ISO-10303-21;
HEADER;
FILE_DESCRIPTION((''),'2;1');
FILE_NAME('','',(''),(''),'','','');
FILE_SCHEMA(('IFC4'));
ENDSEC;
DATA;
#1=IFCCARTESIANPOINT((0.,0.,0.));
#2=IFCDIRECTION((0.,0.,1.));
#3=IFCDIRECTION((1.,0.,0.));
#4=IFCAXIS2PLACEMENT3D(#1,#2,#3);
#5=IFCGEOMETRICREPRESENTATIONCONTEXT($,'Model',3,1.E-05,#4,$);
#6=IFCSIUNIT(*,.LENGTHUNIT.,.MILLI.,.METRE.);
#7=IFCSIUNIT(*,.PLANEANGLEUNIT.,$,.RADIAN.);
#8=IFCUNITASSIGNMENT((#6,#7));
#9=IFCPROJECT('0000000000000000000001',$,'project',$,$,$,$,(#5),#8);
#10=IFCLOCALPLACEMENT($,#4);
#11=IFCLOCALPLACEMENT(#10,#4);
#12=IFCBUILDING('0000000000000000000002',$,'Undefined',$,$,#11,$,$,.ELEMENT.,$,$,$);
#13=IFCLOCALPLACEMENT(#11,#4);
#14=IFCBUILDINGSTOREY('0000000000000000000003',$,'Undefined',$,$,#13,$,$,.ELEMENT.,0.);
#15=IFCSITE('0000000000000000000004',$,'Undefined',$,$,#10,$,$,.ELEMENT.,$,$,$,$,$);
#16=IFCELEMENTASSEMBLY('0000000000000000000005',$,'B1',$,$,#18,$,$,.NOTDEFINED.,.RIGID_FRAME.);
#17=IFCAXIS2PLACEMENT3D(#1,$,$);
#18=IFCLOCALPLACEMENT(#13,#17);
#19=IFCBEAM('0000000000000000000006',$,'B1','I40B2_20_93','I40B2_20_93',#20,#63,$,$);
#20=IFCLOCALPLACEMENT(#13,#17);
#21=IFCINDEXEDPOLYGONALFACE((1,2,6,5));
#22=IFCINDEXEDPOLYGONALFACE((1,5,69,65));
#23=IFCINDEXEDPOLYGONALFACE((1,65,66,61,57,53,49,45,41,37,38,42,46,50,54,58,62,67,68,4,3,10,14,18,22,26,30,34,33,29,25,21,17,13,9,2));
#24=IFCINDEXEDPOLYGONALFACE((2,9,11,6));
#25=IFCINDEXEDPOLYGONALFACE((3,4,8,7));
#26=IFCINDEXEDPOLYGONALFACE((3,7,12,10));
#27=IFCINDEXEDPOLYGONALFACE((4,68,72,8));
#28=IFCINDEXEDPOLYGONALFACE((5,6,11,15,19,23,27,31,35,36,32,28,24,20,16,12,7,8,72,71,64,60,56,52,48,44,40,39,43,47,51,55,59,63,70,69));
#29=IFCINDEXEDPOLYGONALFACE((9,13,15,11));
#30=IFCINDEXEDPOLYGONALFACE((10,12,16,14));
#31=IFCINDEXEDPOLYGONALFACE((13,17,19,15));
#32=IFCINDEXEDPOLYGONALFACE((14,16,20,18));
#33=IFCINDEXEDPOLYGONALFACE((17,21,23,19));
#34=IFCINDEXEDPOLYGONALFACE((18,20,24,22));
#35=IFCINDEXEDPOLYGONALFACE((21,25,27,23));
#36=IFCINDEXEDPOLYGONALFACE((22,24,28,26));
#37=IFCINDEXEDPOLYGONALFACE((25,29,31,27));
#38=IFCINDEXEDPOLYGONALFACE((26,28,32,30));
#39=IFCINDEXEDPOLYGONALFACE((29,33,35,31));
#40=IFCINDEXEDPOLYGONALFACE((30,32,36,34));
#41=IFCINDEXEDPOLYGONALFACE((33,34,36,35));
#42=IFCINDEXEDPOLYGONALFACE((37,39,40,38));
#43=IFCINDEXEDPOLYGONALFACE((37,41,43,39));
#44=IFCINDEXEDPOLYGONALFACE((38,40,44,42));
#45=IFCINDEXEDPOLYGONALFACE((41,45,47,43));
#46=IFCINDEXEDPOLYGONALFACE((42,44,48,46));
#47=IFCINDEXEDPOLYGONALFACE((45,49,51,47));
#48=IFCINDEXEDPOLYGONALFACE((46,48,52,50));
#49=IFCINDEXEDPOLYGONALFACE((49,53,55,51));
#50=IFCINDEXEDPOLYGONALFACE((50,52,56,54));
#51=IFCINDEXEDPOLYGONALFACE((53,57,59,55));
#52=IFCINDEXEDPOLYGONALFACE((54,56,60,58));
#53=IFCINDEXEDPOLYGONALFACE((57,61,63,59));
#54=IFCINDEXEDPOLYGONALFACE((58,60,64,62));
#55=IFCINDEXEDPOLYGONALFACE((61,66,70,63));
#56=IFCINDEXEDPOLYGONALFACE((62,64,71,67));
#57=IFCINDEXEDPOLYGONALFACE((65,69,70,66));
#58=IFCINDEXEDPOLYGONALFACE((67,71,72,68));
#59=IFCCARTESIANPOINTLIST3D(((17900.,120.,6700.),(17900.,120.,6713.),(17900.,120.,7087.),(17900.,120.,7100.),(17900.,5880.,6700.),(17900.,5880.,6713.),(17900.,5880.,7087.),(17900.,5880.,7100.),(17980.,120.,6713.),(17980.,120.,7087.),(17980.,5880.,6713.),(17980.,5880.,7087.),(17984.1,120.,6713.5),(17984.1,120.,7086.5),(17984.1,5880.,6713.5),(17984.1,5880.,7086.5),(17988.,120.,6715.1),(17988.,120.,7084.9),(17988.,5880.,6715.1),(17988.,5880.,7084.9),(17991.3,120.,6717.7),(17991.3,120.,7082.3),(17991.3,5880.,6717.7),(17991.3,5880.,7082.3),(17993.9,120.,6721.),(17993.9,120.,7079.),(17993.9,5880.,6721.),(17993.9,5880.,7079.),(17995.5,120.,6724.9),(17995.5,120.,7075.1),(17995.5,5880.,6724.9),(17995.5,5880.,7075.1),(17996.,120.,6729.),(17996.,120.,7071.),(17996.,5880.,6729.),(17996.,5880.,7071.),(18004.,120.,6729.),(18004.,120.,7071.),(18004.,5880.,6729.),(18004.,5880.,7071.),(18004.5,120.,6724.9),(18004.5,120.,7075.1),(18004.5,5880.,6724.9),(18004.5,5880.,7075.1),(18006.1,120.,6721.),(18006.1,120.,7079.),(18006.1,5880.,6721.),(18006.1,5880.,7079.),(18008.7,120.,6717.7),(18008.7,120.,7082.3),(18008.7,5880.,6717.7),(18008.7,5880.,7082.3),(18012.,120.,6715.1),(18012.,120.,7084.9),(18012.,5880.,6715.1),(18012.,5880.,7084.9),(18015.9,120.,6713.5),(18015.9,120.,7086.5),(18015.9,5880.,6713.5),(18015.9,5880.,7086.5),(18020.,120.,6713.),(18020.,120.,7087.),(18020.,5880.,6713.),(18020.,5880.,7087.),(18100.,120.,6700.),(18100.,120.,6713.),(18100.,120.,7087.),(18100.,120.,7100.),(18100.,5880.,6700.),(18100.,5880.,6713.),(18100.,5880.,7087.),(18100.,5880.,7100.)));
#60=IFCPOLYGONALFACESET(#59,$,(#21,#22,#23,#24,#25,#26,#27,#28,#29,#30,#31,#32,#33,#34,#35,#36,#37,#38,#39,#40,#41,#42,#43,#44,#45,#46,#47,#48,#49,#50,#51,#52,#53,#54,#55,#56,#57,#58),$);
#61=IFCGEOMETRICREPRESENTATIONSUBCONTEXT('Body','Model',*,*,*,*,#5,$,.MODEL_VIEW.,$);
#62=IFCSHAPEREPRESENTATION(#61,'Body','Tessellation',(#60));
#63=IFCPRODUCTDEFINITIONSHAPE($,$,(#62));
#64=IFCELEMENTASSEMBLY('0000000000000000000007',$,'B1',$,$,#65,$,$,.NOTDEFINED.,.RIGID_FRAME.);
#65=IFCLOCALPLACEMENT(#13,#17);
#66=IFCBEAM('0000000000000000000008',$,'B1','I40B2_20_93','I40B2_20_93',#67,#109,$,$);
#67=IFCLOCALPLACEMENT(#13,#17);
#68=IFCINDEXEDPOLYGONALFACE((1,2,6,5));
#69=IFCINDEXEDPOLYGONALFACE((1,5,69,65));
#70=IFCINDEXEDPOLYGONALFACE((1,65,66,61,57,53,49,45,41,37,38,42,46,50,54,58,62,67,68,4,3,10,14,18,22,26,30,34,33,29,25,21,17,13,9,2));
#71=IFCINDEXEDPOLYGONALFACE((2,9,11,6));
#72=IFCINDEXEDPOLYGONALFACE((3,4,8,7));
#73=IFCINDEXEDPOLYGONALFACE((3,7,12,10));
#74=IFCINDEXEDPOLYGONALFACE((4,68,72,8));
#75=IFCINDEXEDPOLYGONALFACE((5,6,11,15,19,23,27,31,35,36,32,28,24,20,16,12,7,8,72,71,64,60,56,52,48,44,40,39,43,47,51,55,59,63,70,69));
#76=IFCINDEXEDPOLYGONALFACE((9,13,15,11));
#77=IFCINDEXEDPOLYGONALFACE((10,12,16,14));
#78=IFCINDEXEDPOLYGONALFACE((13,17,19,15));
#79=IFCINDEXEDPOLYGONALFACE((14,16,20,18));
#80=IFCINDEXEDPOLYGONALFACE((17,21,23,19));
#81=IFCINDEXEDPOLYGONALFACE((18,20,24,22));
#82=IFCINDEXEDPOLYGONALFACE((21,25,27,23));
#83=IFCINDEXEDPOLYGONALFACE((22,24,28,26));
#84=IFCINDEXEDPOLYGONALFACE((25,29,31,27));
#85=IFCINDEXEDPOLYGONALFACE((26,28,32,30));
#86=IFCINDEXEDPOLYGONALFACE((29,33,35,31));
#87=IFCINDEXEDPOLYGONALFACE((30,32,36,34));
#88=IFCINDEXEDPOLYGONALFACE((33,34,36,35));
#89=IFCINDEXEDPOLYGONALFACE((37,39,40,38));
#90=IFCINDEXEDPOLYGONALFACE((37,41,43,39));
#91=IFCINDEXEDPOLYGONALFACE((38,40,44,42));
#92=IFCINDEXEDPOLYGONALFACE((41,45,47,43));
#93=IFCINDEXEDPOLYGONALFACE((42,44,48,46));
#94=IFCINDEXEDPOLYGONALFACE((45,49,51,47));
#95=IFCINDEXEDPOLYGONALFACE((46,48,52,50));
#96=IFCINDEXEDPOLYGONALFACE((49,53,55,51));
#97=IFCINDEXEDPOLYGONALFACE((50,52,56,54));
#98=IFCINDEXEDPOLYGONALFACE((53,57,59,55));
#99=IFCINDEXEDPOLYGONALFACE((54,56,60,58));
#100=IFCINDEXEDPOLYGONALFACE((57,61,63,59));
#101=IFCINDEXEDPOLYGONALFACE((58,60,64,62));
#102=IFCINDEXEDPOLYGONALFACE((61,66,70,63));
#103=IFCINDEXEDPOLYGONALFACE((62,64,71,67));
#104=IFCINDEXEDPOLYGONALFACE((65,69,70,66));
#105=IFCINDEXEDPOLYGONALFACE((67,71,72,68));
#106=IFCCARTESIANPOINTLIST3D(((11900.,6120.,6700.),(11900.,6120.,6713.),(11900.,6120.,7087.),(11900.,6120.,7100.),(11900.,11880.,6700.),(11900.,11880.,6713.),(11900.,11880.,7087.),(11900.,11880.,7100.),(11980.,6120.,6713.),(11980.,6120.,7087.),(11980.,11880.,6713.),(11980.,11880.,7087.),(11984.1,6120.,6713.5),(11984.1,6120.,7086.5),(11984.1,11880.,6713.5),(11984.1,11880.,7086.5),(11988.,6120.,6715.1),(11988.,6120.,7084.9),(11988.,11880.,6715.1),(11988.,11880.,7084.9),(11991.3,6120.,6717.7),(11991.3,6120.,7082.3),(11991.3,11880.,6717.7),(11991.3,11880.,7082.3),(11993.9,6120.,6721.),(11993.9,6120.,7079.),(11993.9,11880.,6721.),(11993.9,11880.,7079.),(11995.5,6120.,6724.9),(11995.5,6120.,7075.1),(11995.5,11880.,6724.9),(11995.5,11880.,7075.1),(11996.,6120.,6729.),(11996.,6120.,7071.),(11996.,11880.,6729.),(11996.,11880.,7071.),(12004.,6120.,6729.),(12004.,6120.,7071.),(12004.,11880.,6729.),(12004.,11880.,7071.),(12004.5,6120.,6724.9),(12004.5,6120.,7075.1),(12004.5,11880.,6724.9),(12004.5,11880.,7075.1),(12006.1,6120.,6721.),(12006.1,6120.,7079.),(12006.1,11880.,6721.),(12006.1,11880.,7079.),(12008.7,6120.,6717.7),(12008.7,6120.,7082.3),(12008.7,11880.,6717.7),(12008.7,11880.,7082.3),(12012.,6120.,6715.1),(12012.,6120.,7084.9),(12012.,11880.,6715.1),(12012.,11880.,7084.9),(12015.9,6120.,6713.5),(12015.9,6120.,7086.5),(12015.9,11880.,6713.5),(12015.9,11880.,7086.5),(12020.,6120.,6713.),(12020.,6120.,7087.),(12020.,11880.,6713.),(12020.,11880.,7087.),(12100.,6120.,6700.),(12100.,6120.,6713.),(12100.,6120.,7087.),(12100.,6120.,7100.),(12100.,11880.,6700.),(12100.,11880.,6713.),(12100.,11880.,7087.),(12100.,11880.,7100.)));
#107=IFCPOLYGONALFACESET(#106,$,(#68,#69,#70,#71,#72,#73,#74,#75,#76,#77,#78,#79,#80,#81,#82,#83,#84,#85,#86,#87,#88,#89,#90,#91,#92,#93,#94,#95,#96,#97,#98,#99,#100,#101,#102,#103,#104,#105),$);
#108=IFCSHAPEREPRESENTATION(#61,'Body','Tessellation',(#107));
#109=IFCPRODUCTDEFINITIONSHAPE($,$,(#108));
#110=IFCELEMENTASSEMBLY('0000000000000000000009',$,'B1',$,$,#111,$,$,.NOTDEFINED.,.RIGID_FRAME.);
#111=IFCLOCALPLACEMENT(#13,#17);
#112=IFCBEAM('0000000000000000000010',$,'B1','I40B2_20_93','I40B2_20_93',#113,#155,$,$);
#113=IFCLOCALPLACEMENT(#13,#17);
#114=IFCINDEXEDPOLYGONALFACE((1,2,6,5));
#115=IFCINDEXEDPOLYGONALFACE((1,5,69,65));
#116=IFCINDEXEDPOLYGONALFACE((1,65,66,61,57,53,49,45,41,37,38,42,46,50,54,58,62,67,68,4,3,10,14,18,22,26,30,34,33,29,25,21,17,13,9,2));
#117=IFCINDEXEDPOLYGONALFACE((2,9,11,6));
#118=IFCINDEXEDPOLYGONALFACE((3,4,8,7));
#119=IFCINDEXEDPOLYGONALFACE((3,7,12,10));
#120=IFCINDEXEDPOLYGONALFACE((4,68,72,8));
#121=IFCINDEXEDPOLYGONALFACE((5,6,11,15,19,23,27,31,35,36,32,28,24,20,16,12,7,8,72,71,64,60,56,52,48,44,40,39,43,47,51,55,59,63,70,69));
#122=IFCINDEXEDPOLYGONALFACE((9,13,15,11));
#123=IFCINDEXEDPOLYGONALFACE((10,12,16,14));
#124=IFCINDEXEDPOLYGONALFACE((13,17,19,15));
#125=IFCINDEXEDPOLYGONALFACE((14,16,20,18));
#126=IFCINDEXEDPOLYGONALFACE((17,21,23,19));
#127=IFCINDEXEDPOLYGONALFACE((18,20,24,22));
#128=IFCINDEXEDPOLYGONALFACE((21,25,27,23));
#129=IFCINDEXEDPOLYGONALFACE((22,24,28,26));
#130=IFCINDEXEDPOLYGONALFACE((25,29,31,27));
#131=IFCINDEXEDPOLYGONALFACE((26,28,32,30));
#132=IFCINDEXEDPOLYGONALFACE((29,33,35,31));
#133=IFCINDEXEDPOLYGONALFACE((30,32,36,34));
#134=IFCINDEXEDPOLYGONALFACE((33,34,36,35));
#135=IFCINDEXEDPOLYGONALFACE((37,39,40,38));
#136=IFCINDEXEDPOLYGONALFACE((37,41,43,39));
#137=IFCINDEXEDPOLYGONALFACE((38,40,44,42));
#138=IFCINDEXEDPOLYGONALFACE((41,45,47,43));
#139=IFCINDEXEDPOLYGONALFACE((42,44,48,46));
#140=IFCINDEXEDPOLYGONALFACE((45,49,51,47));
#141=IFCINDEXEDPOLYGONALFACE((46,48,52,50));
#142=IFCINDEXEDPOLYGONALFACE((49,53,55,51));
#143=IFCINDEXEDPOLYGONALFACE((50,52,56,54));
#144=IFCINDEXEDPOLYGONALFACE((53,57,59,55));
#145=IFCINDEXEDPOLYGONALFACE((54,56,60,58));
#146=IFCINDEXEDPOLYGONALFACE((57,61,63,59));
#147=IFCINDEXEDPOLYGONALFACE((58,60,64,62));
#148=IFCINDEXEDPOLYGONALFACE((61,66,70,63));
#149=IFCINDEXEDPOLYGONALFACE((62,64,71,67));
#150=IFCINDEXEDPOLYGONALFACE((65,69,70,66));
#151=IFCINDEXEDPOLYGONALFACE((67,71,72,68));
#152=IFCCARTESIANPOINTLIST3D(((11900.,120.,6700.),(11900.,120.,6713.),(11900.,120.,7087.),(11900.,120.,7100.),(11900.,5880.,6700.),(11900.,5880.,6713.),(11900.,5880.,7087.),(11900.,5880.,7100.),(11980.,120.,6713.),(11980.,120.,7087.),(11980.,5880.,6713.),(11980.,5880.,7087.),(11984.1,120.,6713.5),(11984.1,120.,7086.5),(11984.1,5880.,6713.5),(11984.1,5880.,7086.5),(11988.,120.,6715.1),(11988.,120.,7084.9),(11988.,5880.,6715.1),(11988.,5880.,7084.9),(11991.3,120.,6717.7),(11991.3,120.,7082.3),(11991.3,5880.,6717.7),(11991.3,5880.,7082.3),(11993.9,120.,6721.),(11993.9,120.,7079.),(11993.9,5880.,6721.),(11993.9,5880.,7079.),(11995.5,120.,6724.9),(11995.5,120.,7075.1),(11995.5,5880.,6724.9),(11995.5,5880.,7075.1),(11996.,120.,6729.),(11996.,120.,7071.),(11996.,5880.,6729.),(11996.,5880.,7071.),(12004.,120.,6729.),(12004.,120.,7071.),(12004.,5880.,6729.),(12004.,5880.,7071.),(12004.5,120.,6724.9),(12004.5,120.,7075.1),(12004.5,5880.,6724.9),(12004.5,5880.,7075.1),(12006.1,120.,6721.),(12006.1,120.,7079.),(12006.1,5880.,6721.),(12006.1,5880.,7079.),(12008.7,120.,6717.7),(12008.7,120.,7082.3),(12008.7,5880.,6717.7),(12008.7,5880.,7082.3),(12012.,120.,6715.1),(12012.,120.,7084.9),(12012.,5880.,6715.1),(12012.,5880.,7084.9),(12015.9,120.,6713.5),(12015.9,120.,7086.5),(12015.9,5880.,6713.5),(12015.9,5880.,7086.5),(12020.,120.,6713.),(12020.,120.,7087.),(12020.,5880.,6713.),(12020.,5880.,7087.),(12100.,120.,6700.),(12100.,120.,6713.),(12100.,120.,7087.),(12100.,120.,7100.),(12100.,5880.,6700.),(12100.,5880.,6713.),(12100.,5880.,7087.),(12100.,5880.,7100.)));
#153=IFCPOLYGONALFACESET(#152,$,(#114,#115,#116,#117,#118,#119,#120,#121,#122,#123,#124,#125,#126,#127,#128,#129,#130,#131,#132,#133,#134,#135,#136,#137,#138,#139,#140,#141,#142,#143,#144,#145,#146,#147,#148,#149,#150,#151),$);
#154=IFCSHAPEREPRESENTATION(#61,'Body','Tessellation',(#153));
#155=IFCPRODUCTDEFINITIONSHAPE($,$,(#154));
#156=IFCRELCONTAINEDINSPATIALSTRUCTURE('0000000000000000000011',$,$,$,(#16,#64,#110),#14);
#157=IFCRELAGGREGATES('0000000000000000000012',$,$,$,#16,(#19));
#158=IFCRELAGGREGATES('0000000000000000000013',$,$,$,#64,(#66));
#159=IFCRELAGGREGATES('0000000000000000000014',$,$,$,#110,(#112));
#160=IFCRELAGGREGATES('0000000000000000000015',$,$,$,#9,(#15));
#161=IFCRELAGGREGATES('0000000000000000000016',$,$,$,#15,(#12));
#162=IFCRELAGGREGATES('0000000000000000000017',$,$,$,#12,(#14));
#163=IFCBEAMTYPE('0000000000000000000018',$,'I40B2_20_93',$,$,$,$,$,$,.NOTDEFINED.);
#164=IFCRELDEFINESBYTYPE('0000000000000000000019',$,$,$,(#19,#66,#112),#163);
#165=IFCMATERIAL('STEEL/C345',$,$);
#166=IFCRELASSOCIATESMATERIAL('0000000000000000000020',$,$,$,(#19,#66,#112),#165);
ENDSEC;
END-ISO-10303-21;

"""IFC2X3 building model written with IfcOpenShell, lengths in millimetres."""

from ifc_helpers import new_model, si_unit, frame, origin_with_axes, origin_2d_with_axis, place, context, subcontext, project, spatial, i_section, extrude, material, type_object, element, aggregate, save


model = new_model("IFC2X3")

# Units and contexts
model_context = context("Model", 3, precision=1e-05, world=origin_with_axes())
body_context = subcontext(model_context, "Body", "Model", "MODEL_VIEW")
ifc_project = project(units=[si_unit("LENGTHUNIT", "METRE", prefix="MILLI"), si_unit("PLANEANGLEUNIT", "RADIAN")], contexts=[model_context])

# Site, building, storey
site_placement = place(None, origin_with_axes())
site = spatial("IfcSite", under=ifc_project, at=site_placement, Name="Undefined", CompositionType="ELEMENT")
building_placement = place(site_placement, origin_with_axes())
building = spatial("IfcBuilding", under=site, at=building_placement, Name="Undefined", CompositionType="ELEMENT")
storey_placement = place(building_placement, origin_with_axes())
storey = spatial("IfcBuildingStorey", under=building, at=storey_placement, Name="Undefined", CompositionType="ELEMENT", Elevation=0.0)

# Element assemblies, beams
ifc_material_1 = material(Name="STEEL/C345")
beam_type_1 = type_object("IfcBeamType", Name="I40B2_20_93", PredefinedType="NOTDEFINED")
assembly_1_placement = place(storey_placement, origin_with_axes())
assembly_1 = element("IfcElementAssembly", 1, at=assembly_1_placement, inside=storey, Name="B1", AssemblyPlace="NOTDEFINED", PredefinedType="RIGID_FRAME")
beam_1_placement = place(assembly_1_placement, frame((18000.0, 120.0, 6900.0), z_axis=(0.0, 0.0, 1.0), x_axis=(0.0, 1.0, 0.0)))
beam_1 = element("IfcBeam", 2, at=beam_1_placement, type_object=beam_type_1, material=ifc_material_1, Name="B1", Description="I40B2_20_93", ObjectType="I40B2_20_93", context=body_context, shape_type="SweptSolid", body=[
    extrude(i_section(OverallWidth=200.0, OverallDepth=400.0, WebThickness=8.0, FlangeThickness=13.0, FilletRadius=16.0, at=origin_2d_with_axis()), frame((5760.0, 0.0, 0.0), z_axis=(-1.0, 0.0, 0.0), x_axis=(0.0, -1.0, 0.0)), (0.0, 0.0, 1.0), 5760.0),
])
aggregate(assembly_1, [beam_1])
assembly_2_placement = place(storey_placement, origin_with_axes())
assembly_2 = element("IfcElementAssembly", 3, at=assembly_2_placement, inside=storey, Name="B1", AssemblyPlace="NOTDEFINED", PredefinedType="RIGID_FRAME")
beam_2_placement = place(assembly_2_placement, frame((12000.0, 6120.0, 6900.0), z_axis=(0.0, 0.0, 1.0), x_axis=(0.0, 1.0, 0.0)))
beam_2 = element("IfcBeam", 4, at=beam_2_placement, type_object=beam_type_1, material=ifc_material_1, Name="B1", Description="I40B2_20_93", ObjectType="I40B2_20_93", context=body_context, shape_type="SweptSolid", body=[
    extrude(i_section(OverallWidth=200.0, OverallDepth=400.0, WebThickness=8.0, FlangeThickness=13.0, FilletRadius=16.0, at=origin_2d_with_axis()), frame((5760.0, 0.0, 0.0), z_axis=(-1.0, 0.0, 0.0), x_axis=(0.0, -1.0, 0.0)), (0.0, 0.0, 1.0), 5760.0),
])
aggregate(assembly_2, [beam_2])
assembly_3_placement = place(storey_placement, origin_with_axes())
assembly_3 = element("IfcElementAssembly", 5, at=assembly_3_placement, inside=storey, Name="B1", AssemblyPlace="NOTDEFINED", PredefinedType="RIGID_FRAME")
beam_3_placement = place(assembly_3_placement, frame((12000.0, 120.0, 6900.0), z_axis=(0.0, 0.0, 1.0), x_axis=(0.0, 1.0, 0.0)))
beam_3 = element("IfcBeam", 6, at=beam_3_placement, type_object=beam_type_1, material=ifc_material_1, Name="B1", Description="I40B2_20_93", ObjectType="I40B2_20_93", context=body_context, shape_type="SweptSolid", body=[
    extrude(i_section(OverallWidth=200.0, OverallDepth=400.0, WebThickness=8.0, FlangeThickness=13.0, FilletRadius=16.0, at=origin_2d_with_axis()), frame((5760.0, 0.0, 0.0), z_axis=(-1.0, 0.0, 0.0), x_axis=(0.0, -1.0, 0.0)), (0.0, 0.0, 1.0), 5760.0),
])
aggregate(assembly_3, [beam_3])

save(model, "model.ifc")
